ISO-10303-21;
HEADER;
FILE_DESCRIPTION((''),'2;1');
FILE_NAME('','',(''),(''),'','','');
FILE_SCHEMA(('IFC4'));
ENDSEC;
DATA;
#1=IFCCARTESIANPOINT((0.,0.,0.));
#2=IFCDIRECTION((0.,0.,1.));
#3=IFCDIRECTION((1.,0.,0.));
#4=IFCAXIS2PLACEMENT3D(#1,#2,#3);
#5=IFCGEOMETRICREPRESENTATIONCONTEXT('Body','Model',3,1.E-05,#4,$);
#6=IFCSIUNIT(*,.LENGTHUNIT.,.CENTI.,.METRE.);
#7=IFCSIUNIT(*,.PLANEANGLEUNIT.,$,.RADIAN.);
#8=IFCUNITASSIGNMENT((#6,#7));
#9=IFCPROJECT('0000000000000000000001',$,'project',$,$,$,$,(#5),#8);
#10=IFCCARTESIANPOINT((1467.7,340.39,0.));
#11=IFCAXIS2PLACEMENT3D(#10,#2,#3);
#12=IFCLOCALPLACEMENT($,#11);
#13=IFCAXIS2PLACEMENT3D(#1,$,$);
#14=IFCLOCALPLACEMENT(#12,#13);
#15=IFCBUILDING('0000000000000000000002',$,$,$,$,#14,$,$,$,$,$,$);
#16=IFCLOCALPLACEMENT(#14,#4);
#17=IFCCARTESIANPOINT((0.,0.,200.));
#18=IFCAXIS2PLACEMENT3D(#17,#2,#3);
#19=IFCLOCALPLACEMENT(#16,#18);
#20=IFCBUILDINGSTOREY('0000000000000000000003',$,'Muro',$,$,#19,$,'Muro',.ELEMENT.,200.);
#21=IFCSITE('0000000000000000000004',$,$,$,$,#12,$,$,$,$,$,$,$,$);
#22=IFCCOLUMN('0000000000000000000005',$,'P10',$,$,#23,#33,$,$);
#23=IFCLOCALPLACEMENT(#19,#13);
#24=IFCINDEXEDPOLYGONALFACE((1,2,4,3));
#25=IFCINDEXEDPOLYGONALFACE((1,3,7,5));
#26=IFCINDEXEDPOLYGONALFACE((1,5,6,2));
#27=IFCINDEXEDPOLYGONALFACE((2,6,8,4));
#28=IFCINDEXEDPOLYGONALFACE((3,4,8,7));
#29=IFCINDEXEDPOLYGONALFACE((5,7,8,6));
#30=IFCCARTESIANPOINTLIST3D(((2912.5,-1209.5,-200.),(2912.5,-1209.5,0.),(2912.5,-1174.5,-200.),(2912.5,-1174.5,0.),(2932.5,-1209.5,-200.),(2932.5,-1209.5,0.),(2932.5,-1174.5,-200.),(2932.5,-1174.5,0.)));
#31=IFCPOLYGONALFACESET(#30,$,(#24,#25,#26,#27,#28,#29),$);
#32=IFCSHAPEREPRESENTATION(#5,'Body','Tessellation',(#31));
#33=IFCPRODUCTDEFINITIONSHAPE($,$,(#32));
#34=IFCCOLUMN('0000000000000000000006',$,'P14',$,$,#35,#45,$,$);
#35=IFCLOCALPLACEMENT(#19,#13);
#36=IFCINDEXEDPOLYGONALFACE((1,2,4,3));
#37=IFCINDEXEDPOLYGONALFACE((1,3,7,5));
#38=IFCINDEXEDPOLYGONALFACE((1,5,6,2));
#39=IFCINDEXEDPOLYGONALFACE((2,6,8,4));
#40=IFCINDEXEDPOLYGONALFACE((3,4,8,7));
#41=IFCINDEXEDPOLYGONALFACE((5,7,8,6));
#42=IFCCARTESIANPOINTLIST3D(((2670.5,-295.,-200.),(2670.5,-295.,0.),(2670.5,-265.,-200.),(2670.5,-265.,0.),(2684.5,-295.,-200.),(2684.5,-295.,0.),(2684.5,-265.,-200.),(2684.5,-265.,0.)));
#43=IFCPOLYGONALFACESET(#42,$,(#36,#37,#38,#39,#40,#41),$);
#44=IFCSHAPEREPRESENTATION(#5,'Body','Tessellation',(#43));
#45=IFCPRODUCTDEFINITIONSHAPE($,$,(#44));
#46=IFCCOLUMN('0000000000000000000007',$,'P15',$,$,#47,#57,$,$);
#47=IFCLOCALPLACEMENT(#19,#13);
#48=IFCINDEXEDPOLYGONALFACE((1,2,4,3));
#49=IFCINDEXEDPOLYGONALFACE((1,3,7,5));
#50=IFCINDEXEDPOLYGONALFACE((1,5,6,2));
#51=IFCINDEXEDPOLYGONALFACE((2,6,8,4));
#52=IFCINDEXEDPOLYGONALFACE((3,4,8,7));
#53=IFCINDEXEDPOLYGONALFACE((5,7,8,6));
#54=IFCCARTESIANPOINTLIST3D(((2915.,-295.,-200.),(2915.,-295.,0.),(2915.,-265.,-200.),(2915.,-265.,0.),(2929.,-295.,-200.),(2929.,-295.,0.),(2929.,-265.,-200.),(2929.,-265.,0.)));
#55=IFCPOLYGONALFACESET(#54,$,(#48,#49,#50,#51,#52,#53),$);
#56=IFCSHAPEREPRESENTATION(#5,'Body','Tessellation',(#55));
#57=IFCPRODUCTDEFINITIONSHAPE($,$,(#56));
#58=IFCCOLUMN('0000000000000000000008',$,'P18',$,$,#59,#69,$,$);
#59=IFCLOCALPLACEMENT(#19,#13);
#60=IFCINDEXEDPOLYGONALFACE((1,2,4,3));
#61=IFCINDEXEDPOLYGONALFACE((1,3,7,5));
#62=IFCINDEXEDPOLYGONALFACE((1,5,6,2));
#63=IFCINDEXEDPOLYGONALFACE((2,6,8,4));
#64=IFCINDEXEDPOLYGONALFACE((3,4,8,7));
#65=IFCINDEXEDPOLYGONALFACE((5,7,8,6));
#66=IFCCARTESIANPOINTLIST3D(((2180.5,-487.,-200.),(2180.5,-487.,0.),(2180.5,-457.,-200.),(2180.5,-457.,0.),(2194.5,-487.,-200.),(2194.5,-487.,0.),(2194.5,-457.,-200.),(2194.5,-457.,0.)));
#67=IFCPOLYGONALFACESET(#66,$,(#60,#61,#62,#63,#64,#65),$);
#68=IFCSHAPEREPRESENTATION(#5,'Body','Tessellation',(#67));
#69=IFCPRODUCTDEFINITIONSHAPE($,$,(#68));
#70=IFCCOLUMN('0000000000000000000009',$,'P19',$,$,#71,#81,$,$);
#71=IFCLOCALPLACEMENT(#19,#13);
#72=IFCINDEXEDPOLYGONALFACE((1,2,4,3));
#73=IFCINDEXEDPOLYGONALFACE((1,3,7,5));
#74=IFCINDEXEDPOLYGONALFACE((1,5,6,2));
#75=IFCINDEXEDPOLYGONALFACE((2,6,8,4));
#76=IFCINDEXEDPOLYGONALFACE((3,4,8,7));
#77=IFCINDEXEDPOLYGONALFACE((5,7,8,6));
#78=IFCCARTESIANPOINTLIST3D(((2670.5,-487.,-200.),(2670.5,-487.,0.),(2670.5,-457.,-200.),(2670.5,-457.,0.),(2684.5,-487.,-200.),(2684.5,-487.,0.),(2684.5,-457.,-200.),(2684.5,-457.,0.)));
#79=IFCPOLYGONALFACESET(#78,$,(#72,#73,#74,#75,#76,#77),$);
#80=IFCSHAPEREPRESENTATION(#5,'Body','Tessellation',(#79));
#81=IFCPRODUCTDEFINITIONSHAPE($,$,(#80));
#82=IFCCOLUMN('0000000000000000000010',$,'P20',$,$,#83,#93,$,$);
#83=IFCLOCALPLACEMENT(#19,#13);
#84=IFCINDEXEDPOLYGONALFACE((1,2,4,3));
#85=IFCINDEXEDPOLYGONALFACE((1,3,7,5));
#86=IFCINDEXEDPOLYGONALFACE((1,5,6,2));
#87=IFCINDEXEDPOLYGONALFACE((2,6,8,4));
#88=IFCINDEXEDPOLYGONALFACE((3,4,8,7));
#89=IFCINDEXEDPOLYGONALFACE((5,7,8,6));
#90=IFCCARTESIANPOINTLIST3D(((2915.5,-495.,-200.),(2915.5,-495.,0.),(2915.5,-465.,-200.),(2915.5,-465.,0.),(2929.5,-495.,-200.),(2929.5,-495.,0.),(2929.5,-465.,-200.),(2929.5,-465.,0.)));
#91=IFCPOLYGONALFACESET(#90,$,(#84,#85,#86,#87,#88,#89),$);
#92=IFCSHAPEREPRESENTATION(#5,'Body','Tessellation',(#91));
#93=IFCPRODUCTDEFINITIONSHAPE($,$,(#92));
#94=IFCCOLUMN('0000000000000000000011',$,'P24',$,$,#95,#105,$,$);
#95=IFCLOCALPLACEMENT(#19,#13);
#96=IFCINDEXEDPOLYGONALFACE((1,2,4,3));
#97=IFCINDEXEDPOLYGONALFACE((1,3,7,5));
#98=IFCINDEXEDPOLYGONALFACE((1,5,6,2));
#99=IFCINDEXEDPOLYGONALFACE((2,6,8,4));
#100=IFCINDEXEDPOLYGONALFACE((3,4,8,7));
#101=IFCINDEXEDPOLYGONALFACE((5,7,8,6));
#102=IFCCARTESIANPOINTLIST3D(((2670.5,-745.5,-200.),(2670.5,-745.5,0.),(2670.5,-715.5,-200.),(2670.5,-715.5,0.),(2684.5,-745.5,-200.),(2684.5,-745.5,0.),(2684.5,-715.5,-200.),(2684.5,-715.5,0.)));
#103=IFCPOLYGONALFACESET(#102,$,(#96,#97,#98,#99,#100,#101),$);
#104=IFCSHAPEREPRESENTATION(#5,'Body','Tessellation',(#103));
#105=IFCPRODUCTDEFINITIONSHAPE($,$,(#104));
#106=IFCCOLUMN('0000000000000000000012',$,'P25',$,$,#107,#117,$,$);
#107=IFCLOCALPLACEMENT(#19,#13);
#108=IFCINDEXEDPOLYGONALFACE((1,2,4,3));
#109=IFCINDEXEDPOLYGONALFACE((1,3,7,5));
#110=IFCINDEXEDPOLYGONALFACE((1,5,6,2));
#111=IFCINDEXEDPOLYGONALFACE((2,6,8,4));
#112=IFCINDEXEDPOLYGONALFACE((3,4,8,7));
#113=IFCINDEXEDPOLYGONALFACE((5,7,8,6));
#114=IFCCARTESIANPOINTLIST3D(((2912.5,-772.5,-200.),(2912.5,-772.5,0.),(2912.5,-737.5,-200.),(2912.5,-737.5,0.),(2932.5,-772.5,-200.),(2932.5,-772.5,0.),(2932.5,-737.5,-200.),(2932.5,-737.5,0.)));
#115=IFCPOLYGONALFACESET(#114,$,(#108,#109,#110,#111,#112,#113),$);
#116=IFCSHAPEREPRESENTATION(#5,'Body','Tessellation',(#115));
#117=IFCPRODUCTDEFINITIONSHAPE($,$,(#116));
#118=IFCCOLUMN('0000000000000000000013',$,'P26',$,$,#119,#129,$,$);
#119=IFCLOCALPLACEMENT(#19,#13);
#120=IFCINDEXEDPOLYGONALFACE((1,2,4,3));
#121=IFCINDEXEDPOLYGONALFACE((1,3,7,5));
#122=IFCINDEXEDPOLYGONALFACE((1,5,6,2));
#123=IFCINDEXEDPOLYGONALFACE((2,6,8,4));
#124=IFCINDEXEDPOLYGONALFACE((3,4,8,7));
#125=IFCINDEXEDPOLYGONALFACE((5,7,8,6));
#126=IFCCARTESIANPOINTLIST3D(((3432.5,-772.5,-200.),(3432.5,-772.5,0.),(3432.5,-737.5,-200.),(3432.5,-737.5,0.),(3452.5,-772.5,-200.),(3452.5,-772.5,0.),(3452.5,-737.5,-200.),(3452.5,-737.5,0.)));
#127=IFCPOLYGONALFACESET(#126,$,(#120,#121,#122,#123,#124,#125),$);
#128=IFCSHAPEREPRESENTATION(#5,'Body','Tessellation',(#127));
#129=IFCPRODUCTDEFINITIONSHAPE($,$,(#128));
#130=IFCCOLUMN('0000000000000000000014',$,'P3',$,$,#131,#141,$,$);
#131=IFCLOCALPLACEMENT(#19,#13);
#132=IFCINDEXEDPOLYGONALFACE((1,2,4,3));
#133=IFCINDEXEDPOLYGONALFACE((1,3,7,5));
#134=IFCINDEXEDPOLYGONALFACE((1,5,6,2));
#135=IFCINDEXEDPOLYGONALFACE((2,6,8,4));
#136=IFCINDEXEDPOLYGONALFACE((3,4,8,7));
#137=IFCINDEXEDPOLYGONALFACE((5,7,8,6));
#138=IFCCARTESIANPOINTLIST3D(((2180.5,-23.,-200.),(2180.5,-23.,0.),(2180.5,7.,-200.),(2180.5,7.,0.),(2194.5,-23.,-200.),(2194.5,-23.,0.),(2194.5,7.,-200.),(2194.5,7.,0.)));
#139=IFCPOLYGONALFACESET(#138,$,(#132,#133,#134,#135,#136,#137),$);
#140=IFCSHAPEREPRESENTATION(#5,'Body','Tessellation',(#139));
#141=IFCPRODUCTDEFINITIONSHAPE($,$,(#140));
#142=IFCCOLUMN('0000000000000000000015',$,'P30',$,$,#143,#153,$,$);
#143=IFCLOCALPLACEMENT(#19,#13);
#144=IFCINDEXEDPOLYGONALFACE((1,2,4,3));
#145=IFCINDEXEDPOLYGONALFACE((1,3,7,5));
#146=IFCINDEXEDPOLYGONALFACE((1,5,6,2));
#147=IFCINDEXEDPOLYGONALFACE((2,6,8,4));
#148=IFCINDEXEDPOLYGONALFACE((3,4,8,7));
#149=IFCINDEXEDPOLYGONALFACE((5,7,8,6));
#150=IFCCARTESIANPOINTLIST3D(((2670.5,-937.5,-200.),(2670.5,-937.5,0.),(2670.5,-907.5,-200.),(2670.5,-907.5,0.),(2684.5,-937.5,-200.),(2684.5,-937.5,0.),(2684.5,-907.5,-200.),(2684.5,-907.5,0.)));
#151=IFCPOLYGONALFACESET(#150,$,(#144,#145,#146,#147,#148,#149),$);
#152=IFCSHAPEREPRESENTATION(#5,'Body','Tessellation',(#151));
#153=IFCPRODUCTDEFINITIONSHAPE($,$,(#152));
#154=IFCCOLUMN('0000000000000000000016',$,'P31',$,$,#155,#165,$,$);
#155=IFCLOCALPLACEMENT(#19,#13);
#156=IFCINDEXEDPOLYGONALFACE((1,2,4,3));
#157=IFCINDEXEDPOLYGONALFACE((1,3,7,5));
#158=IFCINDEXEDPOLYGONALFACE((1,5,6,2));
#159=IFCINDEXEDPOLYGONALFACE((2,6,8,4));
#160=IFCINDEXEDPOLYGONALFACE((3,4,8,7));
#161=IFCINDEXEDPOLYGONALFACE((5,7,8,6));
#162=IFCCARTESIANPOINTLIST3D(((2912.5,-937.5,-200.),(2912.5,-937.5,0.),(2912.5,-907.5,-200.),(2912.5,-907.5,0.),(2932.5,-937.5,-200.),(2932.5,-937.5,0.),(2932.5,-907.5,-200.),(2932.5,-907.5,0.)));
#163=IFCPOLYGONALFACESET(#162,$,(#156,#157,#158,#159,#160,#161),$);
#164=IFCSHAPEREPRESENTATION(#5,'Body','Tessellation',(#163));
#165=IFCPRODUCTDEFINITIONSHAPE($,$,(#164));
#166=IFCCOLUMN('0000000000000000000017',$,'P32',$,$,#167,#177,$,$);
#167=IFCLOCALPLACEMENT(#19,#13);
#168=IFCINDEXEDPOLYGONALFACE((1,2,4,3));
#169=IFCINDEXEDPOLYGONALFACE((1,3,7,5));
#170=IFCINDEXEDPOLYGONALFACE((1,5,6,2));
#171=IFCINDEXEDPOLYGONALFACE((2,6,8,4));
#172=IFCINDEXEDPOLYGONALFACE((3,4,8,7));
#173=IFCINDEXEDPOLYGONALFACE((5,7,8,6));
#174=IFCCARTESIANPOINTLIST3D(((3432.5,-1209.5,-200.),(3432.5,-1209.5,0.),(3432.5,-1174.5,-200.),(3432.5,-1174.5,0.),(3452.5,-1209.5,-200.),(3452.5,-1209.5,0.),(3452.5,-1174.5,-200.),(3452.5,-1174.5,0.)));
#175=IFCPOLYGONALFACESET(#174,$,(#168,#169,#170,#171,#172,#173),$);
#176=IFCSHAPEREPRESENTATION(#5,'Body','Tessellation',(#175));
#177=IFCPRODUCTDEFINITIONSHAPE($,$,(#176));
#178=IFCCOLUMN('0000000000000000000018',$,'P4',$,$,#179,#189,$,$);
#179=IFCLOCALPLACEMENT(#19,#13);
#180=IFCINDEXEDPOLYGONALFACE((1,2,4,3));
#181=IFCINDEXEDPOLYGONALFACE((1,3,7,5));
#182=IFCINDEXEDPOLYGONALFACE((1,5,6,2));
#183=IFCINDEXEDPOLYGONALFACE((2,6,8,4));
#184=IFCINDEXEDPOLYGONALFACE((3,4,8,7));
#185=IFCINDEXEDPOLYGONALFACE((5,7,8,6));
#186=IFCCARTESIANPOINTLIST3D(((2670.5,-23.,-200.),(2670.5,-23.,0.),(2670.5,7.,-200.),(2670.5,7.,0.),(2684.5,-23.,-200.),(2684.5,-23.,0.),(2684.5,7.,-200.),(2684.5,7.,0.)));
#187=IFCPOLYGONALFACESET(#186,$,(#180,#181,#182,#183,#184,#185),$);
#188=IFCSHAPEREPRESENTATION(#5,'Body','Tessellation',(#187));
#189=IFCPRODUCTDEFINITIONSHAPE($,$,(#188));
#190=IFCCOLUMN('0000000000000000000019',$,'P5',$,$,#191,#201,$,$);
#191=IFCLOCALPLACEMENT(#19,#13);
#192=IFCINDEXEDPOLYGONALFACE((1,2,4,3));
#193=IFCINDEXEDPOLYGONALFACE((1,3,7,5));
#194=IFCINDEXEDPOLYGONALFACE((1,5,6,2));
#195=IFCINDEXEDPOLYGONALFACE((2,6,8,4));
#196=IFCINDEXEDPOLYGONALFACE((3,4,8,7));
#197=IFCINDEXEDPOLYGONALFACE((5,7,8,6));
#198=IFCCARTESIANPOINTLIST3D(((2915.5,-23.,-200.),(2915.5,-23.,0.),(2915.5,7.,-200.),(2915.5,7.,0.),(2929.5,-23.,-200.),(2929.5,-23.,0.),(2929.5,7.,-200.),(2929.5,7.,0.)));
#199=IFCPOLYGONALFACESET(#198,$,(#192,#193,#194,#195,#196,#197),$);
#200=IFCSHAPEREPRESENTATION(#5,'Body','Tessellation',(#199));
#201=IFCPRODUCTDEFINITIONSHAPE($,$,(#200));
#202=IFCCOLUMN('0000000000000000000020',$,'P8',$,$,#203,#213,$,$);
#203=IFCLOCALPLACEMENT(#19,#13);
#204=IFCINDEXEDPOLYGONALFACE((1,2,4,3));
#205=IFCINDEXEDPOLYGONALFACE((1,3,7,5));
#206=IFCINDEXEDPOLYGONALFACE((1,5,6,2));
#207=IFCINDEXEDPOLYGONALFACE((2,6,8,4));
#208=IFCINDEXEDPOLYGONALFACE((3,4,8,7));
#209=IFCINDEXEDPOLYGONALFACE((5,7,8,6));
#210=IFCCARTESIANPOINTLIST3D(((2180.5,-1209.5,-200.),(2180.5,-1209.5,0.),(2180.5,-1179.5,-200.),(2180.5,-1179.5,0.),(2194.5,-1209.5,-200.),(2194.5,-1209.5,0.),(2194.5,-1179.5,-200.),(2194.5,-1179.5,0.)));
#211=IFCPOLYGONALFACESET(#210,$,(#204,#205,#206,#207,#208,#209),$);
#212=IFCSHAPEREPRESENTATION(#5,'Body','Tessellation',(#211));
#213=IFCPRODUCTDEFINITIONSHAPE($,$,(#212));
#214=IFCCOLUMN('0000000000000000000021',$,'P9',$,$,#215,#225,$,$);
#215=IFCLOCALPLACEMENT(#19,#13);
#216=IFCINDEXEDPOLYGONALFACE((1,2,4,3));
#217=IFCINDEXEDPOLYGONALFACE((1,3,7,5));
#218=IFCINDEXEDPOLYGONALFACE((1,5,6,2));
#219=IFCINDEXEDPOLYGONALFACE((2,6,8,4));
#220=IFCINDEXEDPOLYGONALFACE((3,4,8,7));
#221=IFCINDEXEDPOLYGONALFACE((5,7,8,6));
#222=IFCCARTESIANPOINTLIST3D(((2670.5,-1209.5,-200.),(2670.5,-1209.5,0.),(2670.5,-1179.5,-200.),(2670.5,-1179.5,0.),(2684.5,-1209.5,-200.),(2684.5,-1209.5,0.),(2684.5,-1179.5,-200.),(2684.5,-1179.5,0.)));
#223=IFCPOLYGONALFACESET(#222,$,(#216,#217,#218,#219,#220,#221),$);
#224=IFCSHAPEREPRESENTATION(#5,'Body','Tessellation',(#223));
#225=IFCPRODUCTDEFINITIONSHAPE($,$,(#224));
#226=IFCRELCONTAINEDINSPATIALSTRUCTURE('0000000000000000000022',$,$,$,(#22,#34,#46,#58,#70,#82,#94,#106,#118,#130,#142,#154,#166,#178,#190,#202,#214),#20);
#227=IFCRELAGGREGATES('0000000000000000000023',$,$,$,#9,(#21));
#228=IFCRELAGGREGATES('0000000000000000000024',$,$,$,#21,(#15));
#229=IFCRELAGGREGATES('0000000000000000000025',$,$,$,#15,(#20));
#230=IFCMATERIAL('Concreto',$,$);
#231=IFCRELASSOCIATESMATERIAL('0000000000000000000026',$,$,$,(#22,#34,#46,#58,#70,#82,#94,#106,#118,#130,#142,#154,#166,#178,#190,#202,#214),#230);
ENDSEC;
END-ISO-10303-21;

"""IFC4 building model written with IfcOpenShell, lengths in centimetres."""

from ifc_helpers import new_model, si_unit, frame, origin, origin_with_axes, origin_2d_with_axis, place, context, project, spatial, rectangle, extrude, material, element, save


model = new_model("IFC4")

# Units and contexts
model_context = context("Model", 3, precision=1e-05, world=origin_with_axes(), identifier="Body")
ifc_project = project(units=[si_unit("LENGTHUNIT", "METRE", prefix="CENTI"), si_unit("PLANEANGLEUNIT", "RADIAN")], contexts=[model_context])

# Site, building, storey
site_placement = place(None, frame((1467.7, 340.39, 0.0), z_axis=(0.0, 0.0, 1.0), x_axis=(1.0, 0.0, 0.0)))
site = spatial("IfcSite", under=ifc_project, at=site_placement)
building_placement = place(site_placement, origin())
building = spatial("IfcBuilding", under=site, at=building_placement)
placement = place(building_placement, origin_with_axes())
storey_placement = place(placement, frame((0.0, 0.0, 200.0), z_axis=(0.0, 0.0, 1.0), x_axis=(1.0, 0.0, 0.0)))
storey = spatial("IfcBuildingStorey", under=building, at=storey_placement, Name="Muro", LongName="Muro", CompositionType="ELEMENT", Elevation=200.0)

# Columns
ifc_material = material(Name="Concreto")
column_1_placement = place(storey_placement, frame((2922.5, -1192.0, 0.0), z_axis=(0.0, 0.0, 1.0), x_axis=(1.0, 0.0, 0.0)))
element("IfcColumn", 1, at=column_1_placement, inside=storey, material=ifc_material, Name="P10", context=model_context, shape_type="SolidModel", body=[
    extrude(rectangle(XDim=20.0, YDim=35.0, at=origin_2d_with_axis()), origin_with_axes(), (0.0, 0.0, -1.0), 200.0),
])
for number, where, z_axis, x_axis, name in (
    (2, (2677.5, -280.0, 0.0), (0.0, 0.0, 1.0), (1.0, 0.0, 0.0), "P14"),
    (3, (2922.0, -280.0, 0.0), (0.0, 0.0, 1.0), (1.0, 0.0, 0.0), "P15"),
):
    element("IfcColumn", number, at=place(storey_placement, frame(where, z_axis=z_axis, x_axis=x_axis)), inside=storey, material=ifc_material, Name=name, context=model_context, shape_type="SolidModel", body=[
        extrude(rectangle(XDim=14.0, YDim=30.0, at=origin_2d_with_axis()), origin_with_axes(), (0.0, 0.0, -1.0), 200.0),
    ])
for number, where, z_axis, x_axis, name in (
    (4, (2187.5, -472.0, 0.0), (0.0, 0.0, 1.0), (1.0, 0.0, 0.0), "P18"),
    (5, (2677.5, -472.0, 0.0), (0.0, 0.0, 1.0), (1.0, 0.0, 0.0), "P19"),
):
    element("IfcColumn", number, at=place(storey_placement, frame(where, z_axis=z_axis, x_axis=x_axis)), inside=storey, material=ifc_material, Name=name, context=model_context, shape_type="SolidModel", body=[
        extrude(rectangle(XDim=14.0, YDim=30.0, at=origin_2d_with_axis()), frame((0.0, 0.0, 0.0), z_axis=(0.0, 0.0, 1.0), x_axis=(-1.0, 0.0, 0.0)), (0.0, 0.0, -1.0), 200.0),
    ])
for number, where, z_axis, x_axis, name in (
    (6, (2922.5, -480.0, 0.0), (0.0, 0.0, 1.0), (1.0, 0.0, 0.0), "P20"),
    (7, (2677.5, -730.5, 0.0), (0.0, 0.0, 1.0), (1.0, 0.0, 0.0), "P24"),
):
    element("IfcColumn", number, at=place(storey_placement, frame(where, z_axis=z_axis, x_axis=x_axis)), inside=storey, material=ifc_material, Name=name, context=model_context, shape_type="SolidModel", body=[
        extrude(rectangle(XDim=14.0, YDim=30.0, at=origin_2d_with_axis()), origin_with_axes(), (0.0, 0.0, -1.0), 200.0),
    ])
column_2_placement = place(storey_placement, frame((2922.5, -755.0, 0.0), z_axis=(0.0, 0.0, 1.0), x_axis=(1.0, 0.0, 0.0)))
element("IfcColumn", 8, at=column_2_placement, inside=storey, material=ifc_material, Name="P25", context=model_context, shape_type="SolidModel", body=[
    extrude(rectangle(XDim=20.0, YDim=35.0, at=origin_2d_with_axis()), frame((0.0, 0.0, 0.0), z_axis=(0.0, 0.0, 1.0), x_axis=(-1.0, 0.0, 0.0)), (0.0, 0.0, -1.0), 200.0),
])
column_3_placement = place(storey_placement, frame((3442.5, -755.0, 0.0), z_axis=(0.0, 0.0, 1.0), x_axis=(1.0, 0.0, 0.0)))
element("IfcColumn", 9, at=column_3_placement, inside=storey, material=ifc_material, Name="P26", context=model_context, shape_type="SolidModel", body=[
    extrude(rectangle(XDim=20.0, YDim=35.0, at=origin_2d_with_axis()), origin_with_axes(), (0.0, 0.0, -1.0), 200.0),
])
for number, where, z_axis, x_axis, name in (
    (10, (2187.5, -8.0, 0.0), (0.0, 0.0, 1.0), (1.0, 0.0, 0.0), "P3"),
    (11, (2677.5, -922.5, 0.0), (0.0, 0.0, 1.0), (1.0, 0.0, 0.0), "P30"),
):
    element("IfcColumn", number, at=place(storey_placement, frame(where, z_axis=z_axis, x_axis=x_axis)), inside=storey, material=ifc_material, Name=name, context=model_context, shape_type="SolidModel", body=[
        extrude(rectangle(XDim=14.0, YDim=30.0, at=origin_2d_with_axis()), origin_with_axes(), (0.0, 0.0, -1.0), 200.0),
    ])
column_4_placement = place(storey_placement, frame((2922.5, -922.5, 0.0), z_axis=(0.0, 0.0, 1.0), x_axis=(1.0, 0.0, 0.0)))
element("IfcColumn", 12, at=column_4_placement, inside=storey, material=ifc_material, Name="P31", context=model_context, shape_type="SolidModel", body=[
    extrude(rectangle(XDim=20.0, YDim=30.0, at=origin_2d_with_axis()), origin_with_axes(), (0.0, 0.0, -1.0), 200.0),
])
column_5_placement = place(storey_placement, frame((3442.5, -1192.0, 0.0), z_axis=(0.0, 0.0, 1.0), x_axis=(1.0, 0.0, 0.0)))
element("IfcColumn", 13, at=column_5_placement, inside=storey, material=ifc_material, Name="P32", context=model_context, shape_type="SolidModel", body=[
    extrude(rectangle(XDim=20.0, YDim=35.0, at=origin_2d_with_axis()), origin_with_axes(), (0.0, 0.0, -1.0), 200.0),
])
for number, where, z_axis, x_axis, name in (
    (14, (2677.5, -8.0, 0.0), (0.0, 0.0, 1.0), (1.0, 0.0, 0.0), "P4"),
    (15, (2922.5, -8.0, 0.0), (0.0, 0.0, 1.0), (1.0, 0.0, 0.0), "P5"),
    (16, (2187.5, -1194.5, 0.0), (0.0, 0.0, 1.0), (1.0, 0.0, 0.0), "P8"),
    (17, (2677.5, -1194.5, 0.0), (0.0, 0.0, 1.0), (1.0, 0.0, 0.0), "P9"),
):
    element("IfcColumn", number, at=place(storey_placement, frame(where, z_axis=z_axis, x_axis=x_axis)), inside=storey, material=ifc_material, Name=name, context=model_context, shape_type="SolidModel", body=[
        extrude(rectangle(XDim=14.0, YDim=30.0, at=origin_2d_with_axis()), origin_with_axes(), (0.0, 0.0, -1.0), 200.0),
    ])

save(model, "model.ifc")
